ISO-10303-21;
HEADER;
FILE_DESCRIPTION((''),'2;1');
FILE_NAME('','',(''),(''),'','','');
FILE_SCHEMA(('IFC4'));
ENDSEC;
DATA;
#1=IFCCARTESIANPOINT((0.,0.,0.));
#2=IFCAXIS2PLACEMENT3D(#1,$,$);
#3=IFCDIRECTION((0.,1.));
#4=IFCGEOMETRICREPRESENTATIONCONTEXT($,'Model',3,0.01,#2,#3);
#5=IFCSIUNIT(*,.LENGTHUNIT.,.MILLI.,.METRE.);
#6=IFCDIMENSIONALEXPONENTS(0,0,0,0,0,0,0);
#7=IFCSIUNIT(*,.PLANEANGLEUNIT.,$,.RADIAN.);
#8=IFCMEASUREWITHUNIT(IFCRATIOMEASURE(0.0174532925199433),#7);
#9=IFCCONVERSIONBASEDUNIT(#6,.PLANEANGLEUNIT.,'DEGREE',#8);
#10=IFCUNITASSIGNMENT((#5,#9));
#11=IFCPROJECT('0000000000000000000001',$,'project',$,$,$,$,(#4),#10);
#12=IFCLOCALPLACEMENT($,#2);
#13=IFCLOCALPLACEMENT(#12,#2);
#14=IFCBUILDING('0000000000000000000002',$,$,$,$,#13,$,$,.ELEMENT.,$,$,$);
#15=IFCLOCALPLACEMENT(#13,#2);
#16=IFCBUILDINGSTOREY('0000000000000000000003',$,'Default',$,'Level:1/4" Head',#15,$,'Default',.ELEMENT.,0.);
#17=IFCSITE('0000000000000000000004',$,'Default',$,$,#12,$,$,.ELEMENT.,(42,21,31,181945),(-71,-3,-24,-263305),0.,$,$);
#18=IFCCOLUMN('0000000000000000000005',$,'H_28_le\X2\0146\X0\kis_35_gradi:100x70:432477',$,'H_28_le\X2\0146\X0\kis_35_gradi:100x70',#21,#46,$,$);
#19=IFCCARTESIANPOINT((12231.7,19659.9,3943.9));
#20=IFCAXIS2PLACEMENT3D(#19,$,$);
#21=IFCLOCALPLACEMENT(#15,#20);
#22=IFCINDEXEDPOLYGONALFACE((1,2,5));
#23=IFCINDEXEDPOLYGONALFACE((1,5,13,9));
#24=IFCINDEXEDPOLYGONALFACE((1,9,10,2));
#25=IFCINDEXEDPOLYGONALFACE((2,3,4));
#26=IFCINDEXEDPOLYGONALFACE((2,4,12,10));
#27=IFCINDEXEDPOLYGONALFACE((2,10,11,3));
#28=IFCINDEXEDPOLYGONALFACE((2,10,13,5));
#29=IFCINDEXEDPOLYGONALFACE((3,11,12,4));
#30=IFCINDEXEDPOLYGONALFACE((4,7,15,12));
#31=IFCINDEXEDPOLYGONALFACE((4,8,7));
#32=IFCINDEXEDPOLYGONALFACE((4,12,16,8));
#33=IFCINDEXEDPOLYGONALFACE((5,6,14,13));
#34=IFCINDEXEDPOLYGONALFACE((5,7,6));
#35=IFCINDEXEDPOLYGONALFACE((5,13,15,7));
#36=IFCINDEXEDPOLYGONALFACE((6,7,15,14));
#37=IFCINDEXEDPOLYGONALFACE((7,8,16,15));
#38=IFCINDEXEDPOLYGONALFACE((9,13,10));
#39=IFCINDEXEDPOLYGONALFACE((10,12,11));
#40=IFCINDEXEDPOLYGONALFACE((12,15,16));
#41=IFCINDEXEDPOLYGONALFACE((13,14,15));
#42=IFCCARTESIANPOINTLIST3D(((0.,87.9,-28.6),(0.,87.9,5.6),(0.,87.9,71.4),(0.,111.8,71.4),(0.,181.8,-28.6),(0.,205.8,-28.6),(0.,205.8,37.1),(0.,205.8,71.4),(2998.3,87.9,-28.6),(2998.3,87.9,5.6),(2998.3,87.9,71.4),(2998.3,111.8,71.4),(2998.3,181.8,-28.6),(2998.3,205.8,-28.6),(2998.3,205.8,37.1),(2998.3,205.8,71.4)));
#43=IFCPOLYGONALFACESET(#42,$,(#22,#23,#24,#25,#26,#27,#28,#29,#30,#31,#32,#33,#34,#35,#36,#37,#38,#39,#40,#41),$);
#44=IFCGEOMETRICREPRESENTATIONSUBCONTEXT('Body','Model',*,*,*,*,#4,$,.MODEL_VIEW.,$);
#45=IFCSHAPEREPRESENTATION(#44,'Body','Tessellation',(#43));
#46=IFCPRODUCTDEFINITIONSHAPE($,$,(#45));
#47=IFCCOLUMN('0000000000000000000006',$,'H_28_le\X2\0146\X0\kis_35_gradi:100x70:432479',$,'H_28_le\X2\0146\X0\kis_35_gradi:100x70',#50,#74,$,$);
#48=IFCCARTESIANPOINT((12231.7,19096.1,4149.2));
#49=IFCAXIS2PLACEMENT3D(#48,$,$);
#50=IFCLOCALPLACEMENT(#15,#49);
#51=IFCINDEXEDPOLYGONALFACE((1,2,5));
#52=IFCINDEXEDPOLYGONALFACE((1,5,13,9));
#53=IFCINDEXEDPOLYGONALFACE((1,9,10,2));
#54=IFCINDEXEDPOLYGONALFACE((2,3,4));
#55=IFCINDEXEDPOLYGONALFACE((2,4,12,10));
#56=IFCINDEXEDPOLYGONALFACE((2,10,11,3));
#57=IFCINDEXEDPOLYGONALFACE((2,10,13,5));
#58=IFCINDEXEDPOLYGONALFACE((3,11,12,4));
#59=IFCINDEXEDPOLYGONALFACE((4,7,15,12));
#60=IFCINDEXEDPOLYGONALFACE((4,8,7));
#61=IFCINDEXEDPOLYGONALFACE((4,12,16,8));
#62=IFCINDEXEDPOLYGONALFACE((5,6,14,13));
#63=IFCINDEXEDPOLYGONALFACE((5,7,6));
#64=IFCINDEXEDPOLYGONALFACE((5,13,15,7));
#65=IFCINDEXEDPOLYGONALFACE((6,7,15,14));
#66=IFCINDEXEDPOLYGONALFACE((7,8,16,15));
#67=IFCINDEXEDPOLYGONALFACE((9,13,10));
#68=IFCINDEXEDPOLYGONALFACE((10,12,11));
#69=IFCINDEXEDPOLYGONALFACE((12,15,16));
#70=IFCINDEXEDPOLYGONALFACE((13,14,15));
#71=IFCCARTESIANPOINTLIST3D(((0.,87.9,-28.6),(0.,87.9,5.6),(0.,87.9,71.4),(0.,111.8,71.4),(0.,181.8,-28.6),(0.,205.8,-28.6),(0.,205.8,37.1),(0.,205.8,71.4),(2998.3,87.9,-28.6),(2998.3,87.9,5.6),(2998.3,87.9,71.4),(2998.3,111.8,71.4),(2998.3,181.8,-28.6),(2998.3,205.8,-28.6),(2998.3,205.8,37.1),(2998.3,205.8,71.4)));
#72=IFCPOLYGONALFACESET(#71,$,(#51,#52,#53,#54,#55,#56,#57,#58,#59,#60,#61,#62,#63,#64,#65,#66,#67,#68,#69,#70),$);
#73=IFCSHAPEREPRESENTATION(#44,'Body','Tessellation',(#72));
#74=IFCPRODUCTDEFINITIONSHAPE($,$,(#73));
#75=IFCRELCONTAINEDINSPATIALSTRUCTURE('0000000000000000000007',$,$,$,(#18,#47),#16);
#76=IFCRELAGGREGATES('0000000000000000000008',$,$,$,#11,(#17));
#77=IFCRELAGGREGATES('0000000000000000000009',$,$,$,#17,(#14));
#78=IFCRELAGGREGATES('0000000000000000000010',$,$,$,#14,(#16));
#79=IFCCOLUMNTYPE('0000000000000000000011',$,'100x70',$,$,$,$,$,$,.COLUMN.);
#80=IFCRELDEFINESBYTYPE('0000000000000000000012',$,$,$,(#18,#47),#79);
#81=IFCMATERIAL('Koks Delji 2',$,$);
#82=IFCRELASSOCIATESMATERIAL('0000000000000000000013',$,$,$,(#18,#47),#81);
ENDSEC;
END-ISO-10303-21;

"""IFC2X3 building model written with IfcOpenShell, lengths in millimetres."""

from ifc_helpers import new_model, entity, si_unit, converted_unit, direction, frame, frame_2d, origin, place, context, subcontext, project, spatial, rectangle, extrude, boolean, source, transform, mapped, material, type_object, type_shapes, element, save


model = new_model("IFC2X3")

# Units and contexts
model_context = context("Model", 3, precision=0.01, world=origin(), true_north=direction((0.0, 1.0)))
body_context = subcontext(model_context, "Body", "Model", "MODEL_VIEW")
ifc_project = project(units=[si_unit("LENGTHUNIT", "METRE", prefix="MILLI"), converted_unit("PLANEANGLEUNIT", "DEGREE", entity("IfcRatioMeasure", 0.0174532925199433), si_unit("PLANEANGLEUNIT", "RADIAN"), dimensions=[0, 0, 0, 0, 0, 0, 0])], contexts=[model_context])

# Site, building, storey
site_placement = place(None, origin())
site = spatial("IfcSite", under=ifc_project, at=site_placement, Name="Default", CompositionType="ELEMENT", RefLatitude=(42, 21, 31, 181945), RefLongitude=(-71, -3, -24, -263305), RefElevation=0.0)
building_placement = place(site_placement, origin())
building = spatial("IfcBuilding", under=site, at=building_placement, CompositionType="ELEMENT")
storey_placement = place(building_placement, origin())
storey = spatial("IfcBuildingStorey", under=building, at=storey_placement, Name="Default", ObjectType="Level:1/4\" Head", LongName="Default", CompositionType="ELEMENT", Elevation=0.0)

# Columns
ifc_material_1 = material(Name="Koks Delji 2")
column_type = type_object("IfcColumnType", Name="100x70", PredefinedType="COLUMN")
shared_shape_1 = source(origin(), body_context, "Body", "CSG", [
    boolean("DIFFERENCE", extrude(rectangle(XDim=2998.3, YDim=117.9, at=frame_2d((0.0, 0.0), x_axis=(1.0, 0.0))), frame((1499.1, 146.8, -28.6)), (0.0, 0.0, 1.0), 100.0), extrude(rectangle(XDim=70.0, YDim=100.0, at=frame_2d((0.0, 0.0), x_axis=(0.0, 1.0))), frame((2998.3, 146.8, 21.4), z_axis=(1.0, 0.0, 0.0), x_axis=(0.0, 0.939693, -0.34202)), (0.0, 0.0, -1.0), 2998.3)),
])
type_shapes(column_type, [shared_shape_1])
for number, where, name in (
    (1, (12231.7, 19659.9, 3943.9), "H_28_leņkis_35_gradi:100x70:432477"),
    (2, (12231.7, 19096.1, 4149.2), "H_28_leņkis_35_gradi:100x70:432479"),
):
    element("IfcColumn", number, at=place(storey_placement, frame(where)), inside=storey, type_object=column_type, material=ifc_material_1, Name=name, ObjectType="H_28_leņkis_35_gradi:100x70", context=body_context, shape_type="MappedRepresentation", body=[
        mapped(shared_shape_1, transform((0.0, 0.0, 0.0), scale=1.0)),
    ])

save(model, "model.ifc")
